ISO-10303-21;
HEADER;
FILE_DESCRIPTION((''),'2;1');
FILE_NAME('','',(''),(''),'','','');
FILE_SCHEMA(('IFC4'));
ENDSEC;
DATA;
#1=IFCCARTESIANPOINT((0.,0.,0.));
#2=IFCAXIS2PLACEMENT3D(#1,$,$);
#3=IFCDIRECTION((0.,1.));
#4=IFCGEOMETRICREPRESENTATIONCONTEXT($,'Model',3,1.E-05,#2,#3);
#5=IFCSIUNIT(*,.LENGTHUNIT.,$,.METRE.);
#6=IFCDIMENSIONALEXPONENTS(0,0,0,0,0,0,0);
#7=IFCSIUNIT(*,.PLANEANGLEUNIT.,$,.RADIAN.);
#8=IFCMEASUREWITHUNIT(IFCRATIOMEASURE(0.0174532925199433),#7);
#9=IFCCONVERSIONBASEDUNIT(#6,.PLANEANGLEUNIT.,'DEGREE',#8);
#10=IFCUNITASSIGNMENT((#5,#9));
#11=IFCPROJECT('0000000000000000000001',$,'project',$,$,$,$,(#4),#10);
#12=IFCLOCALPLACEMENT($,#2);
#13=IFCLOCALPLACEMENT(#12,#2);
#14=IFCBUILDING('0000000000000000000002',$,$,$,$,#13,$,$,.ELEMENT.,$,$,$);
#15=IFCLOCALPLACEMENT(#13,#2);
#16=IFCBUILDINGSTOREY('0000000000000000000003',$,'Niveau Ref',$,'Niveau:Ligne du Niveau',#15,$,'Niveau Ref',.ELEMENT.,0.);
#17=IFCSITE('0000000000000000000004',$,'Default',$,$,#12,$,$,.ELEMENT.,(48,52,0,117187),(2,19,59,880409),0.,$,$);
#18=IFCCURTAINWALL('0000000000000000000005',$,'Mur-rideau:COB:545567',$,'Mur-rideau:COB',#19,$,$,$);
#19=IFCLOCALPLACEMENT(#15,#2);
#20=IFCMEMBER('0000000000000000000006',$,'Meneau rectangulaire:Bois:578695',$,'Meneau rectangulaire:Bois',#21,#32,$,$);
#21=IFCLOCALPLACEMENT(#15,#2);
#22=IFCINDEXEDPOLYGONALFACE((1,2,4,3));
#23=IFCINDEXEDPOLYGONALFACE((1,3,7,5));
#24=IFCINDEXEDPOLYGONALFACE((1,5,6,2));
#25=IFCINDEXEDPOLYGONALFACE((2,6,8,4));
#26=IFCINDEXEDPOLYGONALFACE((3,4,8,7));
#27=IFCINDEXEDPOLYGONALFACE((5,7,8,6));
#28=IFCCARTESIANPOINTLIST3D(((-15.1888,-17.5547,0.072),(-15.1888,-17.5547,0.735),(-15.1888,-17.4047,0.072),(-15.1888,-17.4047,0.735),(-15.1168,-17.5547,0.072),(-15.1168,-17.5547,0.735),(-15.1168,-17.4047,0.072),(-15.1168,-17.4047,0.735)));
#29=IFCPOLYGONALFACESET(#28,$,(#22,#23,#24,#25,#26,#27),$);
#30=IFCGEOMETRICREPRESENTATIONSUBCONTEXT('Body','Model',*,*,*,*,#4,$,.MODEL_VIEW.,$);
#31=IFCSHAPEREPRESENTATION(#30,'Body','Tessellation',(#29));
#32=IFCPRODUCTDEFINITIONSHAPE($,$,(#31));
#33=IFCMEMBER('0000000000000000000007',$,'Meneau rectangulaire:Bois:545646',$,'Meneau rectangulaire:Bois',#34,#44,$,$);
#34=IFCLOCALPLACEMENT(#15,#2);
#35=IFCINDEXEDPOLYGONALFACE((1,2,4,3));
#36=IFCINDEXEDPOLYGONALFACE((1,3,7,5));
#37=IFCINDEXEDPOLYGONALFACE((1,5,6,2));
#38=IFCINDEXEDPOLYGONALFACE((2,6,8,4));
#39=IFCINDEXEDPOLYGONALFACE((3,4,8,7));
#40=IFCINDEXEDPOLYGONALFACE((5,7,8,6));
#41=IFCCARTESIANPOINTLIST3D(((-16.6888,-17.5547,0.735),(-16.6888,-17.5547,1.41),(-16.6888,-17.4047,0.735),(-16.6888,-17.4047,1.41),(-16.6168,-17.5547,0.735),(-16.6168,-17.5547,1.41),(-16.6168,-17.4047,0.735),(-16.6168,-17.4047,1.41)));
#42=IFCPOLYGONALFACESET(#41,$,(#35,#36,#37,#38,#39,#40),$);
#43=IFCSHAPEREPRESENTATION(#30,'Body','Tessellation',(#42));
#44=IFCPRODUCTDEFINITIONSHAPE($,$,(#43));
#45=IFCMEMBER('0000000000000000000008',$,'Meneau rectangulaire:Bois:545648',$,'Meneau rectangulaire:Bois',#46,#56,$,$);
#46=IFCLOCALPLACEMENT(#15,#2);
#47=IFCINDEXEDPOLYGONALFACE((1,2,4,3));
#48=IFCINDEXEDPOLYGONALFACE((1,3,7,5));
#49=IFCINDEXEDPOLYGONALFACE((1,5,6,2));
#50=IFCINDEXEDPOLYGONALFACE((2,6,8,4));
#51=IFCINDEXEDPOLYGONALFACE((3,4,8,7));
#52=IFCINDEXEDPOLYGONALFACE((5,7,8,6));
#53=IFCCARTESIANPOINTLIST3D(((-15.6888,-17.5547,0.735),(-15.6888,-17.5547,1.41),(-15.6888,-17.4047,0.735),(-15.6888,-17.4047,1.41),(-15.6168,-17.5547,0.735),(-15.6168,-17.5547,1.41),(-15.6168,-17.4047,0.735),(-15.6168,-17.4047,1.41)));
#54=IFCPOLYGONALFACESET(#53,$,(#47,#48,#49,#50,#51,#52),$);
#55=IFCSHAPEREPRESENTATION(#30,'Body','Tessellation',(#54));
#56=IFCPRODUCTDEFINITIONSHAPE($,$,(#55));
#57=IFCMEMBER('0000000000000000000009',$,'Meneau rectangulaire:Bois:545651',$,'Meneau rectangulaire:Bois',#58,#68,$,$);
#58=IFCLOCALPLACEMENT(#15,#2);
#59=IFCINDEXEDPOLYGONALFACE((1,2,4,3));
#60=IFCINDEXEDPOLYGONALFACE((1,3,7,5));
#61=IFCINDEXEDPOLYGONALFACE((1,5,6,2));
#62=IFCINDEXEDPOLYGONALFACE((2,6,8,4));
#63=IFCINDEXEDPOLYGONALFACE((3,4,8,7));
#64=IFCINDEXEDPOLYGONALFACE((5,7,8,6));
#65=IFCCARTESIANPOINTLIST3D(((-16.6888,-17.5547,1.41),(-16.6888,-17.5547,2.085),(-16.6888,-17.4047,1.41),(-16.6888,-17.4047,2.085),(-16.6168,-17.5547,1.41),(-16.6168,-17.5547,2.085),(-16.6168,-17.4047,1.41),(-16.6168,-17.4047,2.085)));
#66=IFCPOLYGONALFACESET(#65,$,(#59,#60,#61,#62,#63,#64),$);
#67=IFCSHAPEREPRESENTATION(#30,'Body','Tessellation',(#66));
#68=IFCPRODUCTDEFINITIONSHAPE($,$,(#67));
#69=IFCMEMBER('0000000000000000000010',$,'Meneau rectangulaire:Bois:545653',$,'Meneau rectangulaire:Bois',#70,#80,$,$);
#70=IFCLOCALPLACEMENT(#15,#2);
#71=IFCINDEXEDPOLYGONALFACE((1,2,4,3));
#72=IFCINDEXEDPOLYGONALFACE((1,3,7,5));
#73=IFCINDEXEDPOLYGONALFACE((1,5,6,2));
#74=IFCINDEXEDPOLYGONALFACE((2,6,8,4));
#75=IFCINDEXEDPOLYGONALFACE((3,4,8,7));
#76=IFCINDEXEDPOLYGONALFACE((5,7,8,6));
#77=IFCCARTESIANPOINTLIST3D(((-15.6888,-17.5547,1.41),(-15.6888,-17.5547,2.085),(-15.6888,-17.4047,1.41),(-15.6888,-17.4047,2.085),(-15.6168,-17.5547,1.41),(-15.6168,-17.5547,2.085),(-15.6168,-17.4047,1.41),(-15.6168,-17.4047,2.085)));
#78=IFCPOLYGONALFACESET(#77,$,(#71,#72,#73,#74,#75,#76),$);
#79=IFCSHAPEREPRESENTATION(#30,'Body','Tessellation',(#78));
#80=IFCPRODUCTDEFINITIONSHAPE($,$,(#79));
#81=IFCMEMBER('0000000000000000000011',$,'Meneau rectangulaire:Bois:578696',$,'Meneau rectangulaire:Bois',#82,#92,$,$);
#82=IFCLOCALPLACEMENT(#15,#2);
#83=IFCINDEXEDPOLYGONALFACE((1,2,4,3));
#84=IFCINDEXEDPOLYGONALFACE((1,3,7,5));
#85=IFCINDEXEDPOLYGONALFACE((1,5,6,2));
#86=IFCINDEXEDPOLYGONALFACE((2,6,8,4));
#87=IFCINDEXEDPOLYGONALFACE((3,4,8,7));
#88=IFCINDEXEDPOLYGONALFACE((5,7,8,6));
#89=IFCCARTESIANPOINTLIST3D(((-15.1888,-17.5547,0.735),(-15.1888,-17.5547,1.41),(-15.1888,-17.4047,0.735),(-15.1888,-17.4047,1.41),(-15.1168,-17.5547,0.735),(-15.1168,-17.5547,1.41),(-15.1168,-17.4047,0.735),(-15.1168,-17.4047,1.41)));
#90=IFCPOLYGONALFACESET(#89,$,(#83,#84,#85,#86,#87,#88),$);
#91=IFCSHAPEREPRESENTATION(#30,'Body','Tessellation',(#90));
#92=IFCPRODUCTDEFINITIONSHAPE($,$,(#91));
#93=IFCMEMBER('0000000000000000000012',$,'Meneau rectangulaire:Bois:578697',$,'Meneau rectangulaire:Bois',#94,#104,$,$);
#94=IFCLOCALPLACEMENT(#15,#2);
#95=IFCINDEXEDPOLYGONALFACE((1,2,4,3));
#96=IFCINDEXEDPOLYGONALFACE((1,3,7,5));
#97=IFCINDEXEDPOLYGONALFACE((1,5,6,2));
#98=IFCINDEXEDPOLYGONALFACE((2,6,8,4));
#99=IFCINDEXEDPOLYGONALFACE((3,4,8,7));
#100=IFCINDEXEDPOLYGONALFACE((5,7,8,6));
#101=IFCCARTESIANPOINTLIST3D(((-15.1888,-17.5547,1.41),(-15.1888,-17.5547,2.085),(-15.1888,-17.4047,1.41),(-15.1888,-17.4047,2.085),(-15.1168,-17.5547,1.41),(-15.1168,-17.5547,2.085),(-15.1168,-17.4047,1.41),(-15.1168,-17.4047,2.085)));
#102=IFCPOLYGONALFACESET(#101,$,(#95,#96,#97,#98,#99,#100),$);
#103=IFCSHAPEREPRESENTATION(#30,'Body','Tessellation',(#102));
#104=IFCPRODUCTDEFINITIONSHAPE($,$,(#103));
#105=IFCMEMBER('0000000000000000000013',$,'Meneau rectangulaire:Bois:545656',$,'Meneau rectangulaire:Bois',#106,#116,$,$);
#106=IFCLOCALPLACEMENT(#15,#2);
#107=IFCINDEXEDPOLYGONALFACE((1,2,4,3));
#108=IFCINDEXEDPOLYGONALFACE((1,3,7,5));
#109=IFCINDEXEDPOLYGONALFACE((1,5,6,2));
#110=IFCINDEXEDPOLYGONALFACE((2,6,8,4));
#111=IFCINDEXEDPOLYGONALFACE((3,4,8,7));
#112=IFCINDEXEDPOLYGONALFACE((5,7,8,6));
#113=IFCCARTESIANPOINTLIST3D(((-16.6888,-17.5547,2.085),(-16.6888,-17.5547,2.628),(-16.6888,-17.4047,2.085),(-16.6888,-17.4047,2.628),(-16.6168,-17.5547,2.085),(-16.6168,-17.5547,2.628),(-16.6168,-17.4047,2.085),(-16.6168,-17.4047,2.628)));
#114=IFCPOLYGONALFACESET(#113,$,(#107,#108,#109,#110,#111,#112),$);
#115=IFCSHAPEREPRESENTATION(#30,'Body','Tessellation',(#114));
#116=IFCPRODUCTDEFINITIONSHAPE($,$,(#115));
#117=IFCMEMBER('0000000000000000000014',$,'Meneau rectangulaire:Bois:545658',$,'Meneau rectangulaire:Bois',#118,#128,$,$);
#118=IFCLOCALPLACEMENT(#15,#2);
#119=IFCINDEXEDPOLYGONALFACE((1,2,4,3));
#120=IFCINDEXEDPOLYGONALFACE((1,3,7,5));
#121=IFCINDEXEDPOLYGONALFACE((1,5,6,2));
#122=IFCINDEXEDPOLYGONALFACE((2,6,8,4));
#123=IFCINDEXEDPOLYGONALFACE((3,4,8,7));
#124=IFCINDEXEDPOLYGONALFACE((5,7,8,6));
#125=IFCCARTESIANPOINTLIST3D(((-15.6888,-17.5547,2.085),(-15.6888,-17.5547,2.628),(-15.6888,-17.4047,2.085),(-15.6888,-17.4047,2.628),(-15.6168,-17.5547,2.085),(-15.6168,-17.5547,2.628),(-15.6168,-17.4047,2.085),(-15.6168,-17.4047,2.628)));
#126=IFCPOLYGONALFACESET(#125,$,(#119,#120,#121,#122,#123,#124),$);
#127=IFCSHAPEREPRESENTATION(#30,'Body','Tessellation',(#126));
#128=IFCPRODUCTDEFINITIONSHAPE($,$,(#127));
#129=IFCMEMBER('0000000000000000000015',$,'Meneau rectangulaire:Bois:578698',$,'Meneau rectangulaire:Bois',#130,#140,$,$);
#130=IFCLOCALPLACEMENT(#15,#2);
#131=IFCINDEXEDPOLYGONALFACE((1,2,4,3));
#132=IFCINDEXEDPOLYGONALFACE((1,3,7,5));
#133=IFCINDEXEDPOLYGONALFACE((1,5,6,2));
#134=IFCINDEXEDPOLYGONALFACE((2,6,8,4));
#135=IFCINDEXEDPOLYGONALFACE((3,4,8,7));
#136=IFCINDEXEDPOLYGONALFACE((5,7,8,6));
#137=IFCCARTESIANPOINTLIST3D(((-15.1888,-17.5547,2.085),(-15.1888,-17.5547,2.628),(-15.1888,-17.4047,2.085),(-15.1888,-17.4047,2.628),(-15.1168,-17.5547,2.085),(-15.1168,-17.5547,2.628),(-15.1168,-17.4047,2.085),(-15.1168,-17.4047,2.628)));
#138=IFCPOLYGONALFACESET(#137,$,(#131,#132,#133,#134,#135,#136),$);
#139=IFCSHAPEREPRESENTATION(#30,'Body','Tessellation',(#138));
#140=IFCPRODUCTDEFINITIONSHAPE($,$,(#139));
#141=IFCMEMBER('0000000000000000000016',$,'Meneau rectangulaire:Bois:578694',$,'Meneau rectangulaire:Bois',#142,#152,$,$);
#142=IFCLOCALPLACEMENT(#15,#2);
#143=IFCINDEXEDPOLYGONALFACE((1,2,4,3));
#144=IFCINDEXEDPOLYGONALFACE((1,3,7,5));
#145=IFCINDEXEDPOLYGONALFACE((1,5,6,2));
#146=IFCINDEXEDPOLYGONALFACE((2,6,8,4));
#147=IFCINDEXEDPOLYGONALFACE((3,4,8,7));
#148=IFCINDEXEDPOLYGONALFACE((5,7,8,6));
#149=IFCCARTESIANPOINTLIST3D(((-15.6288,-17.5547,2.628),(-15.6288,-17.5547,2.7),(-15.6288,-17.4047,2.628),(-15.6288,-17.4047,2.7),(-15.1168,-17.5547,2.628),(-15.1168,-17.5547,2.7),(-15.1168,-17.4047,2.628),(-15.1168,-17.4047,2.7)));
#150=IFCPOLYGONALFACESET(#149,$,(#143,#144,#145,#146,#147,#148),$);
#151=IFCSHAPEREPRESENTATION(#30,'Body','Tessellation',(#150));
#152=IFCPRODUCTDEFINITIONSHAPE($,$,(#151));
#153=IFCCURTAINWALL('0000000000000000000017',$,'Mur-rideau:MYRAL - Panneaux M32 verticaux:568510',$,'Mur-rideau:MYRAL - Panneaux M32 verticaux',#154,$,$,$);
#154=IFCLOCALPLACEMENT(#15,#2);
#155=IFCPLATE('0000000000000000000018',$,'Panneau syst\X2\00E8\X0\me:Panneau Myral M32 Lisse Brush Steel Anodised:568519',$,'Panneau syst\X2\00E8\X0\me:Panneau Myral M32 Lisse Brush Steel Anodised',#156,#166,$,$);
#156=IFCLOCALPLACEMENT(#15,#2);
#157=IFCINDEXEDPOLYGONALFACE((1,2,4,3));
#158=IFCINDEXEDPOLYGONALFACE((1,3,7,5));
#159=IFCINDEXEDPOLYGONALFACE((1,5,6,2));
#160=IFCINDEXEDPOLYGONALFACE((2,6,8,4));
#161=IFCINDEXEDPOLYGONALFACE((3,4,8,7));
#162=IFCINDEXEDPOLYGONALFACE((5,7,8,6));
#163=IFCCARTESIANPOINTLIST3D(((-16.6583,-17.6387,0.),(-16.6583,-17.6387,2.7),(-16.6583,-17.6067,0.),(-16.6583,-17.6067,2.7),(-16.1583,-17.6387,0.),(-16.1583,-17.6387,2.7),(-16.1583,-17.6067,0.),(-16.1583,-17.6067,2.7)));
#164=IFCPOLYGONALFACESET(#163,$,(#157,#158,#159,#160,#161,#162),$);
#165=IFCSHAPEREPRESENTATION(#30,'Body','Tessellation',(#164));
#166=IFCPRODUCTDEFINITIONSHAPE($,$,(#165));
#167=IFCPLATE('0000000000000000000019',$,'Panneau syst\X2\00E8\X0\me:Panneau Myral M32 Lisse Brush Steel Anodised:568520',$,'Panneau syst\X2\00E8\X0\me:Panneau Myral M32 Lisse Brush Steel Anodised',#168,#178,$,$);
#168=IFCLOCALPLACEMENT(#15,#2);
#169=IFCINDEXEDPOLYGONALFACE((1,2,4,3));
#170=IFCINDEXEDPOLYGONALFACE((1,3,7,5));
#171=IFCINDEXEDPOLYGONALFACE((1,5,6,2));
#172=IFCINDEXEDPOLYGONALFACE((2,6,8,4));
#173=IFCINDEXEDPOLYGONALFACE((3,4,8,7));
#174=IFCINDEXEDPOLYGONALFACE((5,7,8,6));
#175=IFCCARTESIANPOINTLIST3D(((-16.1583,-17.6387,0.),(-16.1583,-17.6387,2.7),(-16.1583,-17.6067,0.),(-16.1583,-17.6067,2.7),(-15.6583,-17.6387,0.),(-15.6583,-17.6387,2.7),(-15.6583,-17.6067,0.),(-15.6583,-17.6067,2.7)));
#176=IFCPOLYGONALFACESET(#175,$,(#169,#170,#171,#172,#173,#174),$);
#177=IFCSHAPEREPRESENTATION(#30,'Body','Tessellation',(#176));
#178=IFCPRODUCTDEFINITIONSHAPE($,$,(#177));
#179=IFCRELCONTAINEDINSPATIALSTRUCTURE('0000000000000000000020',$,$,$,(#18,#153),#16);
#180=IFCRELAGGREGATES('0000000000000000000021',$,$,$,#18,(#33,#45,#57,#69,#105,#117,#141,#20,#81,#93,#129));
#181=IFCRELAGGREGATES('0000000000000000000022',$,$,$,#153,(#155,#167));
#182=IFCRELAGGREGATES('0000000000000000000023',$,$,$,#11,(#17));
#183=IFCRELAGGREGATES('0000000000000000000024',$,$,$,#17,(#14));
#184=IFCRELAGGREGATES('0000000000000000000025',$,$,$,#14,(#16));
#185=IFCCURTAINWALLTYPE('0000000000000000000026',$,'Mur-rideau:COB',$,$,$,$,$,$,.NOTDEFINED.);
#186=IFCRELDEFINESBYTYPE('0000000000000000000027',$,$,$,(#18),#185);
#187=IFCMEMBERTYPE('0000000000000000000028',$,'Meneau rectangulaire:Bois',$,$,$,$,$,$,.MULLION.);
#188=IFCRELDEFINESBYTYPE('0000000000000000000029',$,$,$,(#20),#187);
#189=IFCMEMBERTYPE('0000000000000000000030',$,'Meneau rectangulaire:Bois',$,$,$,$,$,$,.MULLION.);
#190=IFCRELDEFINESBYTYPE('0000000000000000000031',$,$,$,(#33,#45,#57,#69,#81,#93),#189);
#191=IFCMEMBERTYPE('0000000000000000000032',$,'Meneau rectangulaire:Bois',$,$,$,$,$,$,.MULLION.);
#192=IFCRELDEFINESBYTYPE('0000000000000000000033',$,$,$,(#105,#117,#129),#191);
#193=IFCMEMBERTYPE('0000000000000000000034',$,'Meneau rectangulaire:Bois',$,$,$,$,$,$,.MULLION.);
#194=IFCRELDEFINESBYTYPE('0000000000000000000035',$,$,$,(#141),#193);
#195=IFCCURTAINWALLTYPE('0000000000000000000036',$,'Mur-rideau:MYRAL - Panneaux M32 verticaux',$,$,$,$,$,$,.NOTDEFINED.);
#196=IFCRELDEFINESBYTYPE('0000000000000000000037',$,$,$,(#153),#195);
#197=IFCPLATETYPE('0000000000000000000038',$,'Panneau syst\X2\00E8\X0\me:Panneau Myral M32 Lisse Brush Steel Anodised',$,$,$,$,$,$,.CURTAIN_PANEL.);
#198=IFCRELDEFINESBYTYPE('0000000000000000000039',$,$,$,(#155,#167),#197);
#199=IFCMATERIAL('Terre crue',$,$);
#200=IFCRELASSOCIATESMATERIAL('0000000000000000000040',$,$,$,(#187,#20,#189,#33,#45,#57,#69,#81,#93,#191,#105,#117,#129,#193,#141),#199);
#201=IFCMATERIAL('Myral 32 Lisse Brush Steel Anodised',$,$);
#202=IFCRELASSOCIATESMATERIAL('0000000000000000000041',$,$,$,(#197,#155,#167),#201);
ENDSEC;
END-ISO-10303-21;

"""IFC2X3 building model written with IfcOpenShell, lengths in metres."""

from ifc_helpers import new_model, entity, si_unit, converted_unit, direction, frame, origin, origin_2d_with_axis, place, context, subcontext, project, spatial, rectangle, extrude, source, transform, mapped, material, type_object, type_shapes, element, aggregate, save


model = new_model("IFC2X3")

# Units and contexts
model_context = context("Model", 3, precision=1e-05, world=origin(), true_north=direction((0.0, 1.0)))
body_context = subcontext(model_context, "Body", "Model", "MODEL_VIEW")
ifc_project = project(units=[si_unit("LENGTHUNIT", "METRE"), converted_unit("PLANEANGLEUNIT", "DEGREE", entity("IfcRatioMeasure", 0.0174532925199433), si_unit("PLANEANGLEUNIT", "RADIAN"), dimensions=[0, 0, 0, 0, 0, 0, 0])], contexts=[model_context])

# Site, building, storey
site_placement = place(None, origin())
site = spatial("IfcSite", under=ifc_project, at=site_placement, Name="Default", CompositionType="ELEMENT", RefLatitude=(48, 52, 0, 117187), RefLongitude=(2, 19, 59, 880409), RefElevation=0.0)
building_placement = place(site_placement, origin())
building = spatial("IfcBuilding", under=site, at=building_placement, CompositionType="ELEMENT")
storey_placement = place(building_placement, origin())
storey = spatial("IfcBuildingStorey", under=building, at=storey_placement, Name="Niveau Ref", ObjectType="Niveau:Ligne du Niveau", LongName="Niveau Ref", CompositionType="ELEMENT", Elevation=0.0)

# Curtain wall, members
curtain_wall_type_1 = type_object("IfcCurtainWallType", Name="Mur-rideau:COB", PredefinedType="NOTDEFINED")
curtain_wall_1_placement = place(storey_placement, origin())
curtain_wall_1 = element("IfcCurtainWall", 1, at=curtain_wall_1_placement, inside=storey, type_object=curtain_wall_type_1, Name="Mur-rideau:COB:545567", ObjectType="Mur-rideau:COB")
ifc_material_1 = material(Name="Terre crue")
member_type_1 = type_object("IfcMemberType", Name="Meneau rectangulaire:Bois", PredefinedType="MULLION", material=ifc_material_1)
shared_shape_1 = source(origin(), body_context, "Body", "SweptSolid", [
    extrude(rectangle(XDim=0.15, YDim=0.072, at=origin_2d_with_axis()), frame((-0.024, 0.0, -0.663), z_axis=(0.0, 0.0, 1.0), x_axis=(0.0, -1.0, 0.0)), (0.0, 0.0, 1.0), 0.663),
])
type_shapes(member_type_1, [shared_shape_1])
member_1_placement = place(storey_placement, frame((-15.1288, -17.4797, 0.072), z_axis=(0.0, 0.0, -1.0), x_axis=(1.0, 0.0, 0.0)))
member_1 = element("IfcMember", 2, at=member_1_placement, type_object=member_type_1, material=ifc_material_1, Name="Meneau rectangulaire:Bois:578695", ObjectType="Meneau rectangulaire:Bois", context=body_context, shape_type="MappedRepresentation", body=[
    mapped(shared_shape_1, transform((0.0, 0.0, 0.0), scale=1.0)),
])
member_type_2 = type_object("IfcMemberType", Name="Meneau rectangulaire:Bois", PredefinedType="MULLION", material=ifc_material_1)
shared_shape_2 = source(origin(), body_context, "Body", "SweptSolid", [
    extrude(rectangle(XDim=0.15, YDim=0.072, at=origin_2d_with_axis()), frame((-0.024, 0.0, -0.675), z_axis=(0.0, 0.0, 1.0), x_axis=(0.0, -1.0, 0.0)), (0.0, 0.0, 1.0), 0.675),
])
type_shapes(member_type_2, [shared_shape_2])
member_2_placement = place(storey_placement, frame((-16.6288, -17.4797, 0.735), z_axis=(0.0, 0.0, -1.0), x_axis=(1.0, 0.0, 0.0)))
member_2 = element("IfcMember", 3, at=member_2_placement, type_object=member_type_2, material=ifc_material_1, Name="Meneau rectangulaire:Bois:545646", ObjectType="Meneau rectangulaire:Bois", context=body_context, shape_type="MappedRepresentation", body=[
    mapped(shared_shape_2, transform((0.0, 0.0, 0.0), scale=1.0)),
])
member_3_placement = place(storey_placement, frame((-15.6288, -17.4797, 0.735), z_axis=(0.0, 0.0, -1.0), x_axis=(1.0, 0.0, 0.0)))
member_3 = element("IfcMember", 4, at=member_3_placement, type_object=member_type_2, material=ifc_material_1, Name="Meneau rectangulaire:Bois:545648", ObjectType="Meneau rectangulaire:Bois", context=body_context, shape_type="MappedRepresentation", body=[
    mapped(shared_shape_2, transform((0.0, 0.0, 0.0), scale=1.0)),
])
member_4_placement = place(storey_placement, frame((-16.6288, -17.4797, 1.41), z_axis=(0.0, 0.0, -1.0), x_axis=(1.0, 0.0, 0.0)))
member_4 = element("IfcMember", 5, at=member_4_placement, type_object=member_type_2, material=ifc_material_1, Name="Meneau rectangulaire:Bois:545651", ObjectType="Meneau rectangulaire:Bois", context=body_context, shape_type="MappedRepresentation", body=[
    mapped(shared_shape_2, transform((0.0, 0.0, 0.0), scale=1.0)),
])
member_5_placement = place(storey_placement, frame((-15.6288, -17.4797, 1.41), z_axis=(0.0, 0.0, -1.0), x_axis=(1.0, 0.0, 0.0)))
member_5 = element("IfcMember", 6, at=member_5_placement, type_object=member_type_2, material=ifc_material_1, Name="Meneau rectangulaire:Bois:545653", ObjectType="Meneau rectangulaire:Bois", context=body_context, shape_type="MappedRepresentation", body=[
    mapped(shared_shape_2, transform((0.0, 0.0, 0.0), scale=1.0)),
])
member_6_placement = place(storey_placement, frame((-15.1288, -17.4797, 0.735), z_axis=(0.0, 0.0, -1.0), x_axis=(1.0, 0.0, 0.0)))
member_6 = element("IfcMember", 7, at=member_6_placement, type_object=member_type_2, material=ifc_material_1, Name="Meneau rectangulaire:Bois:578696", ObjectType="Meneau rectangulaire:Bois", context=body_context, shape_type="MappedRepresentation", body=[
    mapped(shared_shape_2, transform((0.0, 0.0, 0.0), scale=1.0)),
])
member_7_placement = place(storey_placement, frame((-15.1288, -17.4797, 1.41), z_axis=(0.0, 0.0, -1.0), x_axis=(1.0, 0.0, 0.0)))
member_7 = element("IfcMember", 8, at=member_7_placement, type_object=member_type_2, material=ifc_material_1, Name="Meneau rectangulaire:Bois:578697", ObjectType="Meneau rectangulaire:Bois", context=body_context, shape_type="MappedRepresentation", body=[
    mapped(shared_shape_2, transform((0.0, 0.0, 0.0), scale=1.0)),
])
member_type_3 = type_object("IfcMemberType", Name="Meneau rectangulaire:Bois", PredefinedType="MULLION", material=ifc_material_1)
shared_shape_3 = source(origin(), body_context, "Body", "SweptSolid", [
    extrude(rectangle(XDim=0.15, YDim=0.072, at=origin_2d_with_axis()), frame((-0.024, 0.0, -0.543), z_axis=(0.0, 0.0, 1.0), x_axis=(0.0, -1.0, 0.0)), (0.0, 0.0, 1.0), 0.543),
])
type_shapes(member_type_3, [shared_shape_3])
member_8_placement = place(storey_placement, frame((-16.6288, -17.4797, 2.085), z_axis=(0.0, 0.0, -1.0), x_axis=(1.0, 0.0, 0.0)))
member_8 = element("IfcMember", 9, at=member_8_placement, type_object=member_type_3, material=ifc_material_1, Name="Meneau rectangulaire:Bois:545656", ObjectType="Meneau rectangulaire:Bois", context=body_context, shape_type="MappedRepresentation", body=[
    mapped(shared_shape_3, transform((0.0, 0.0, 0.0), scale=1.0)),
])
member_9_placement = place(storey_placement, frame((-15.6288, -17.4797, 2.085), z_axis=(0.0, 0.0, -1.0), x_axis=(1.0, 0.0, 0.0)))
member_9 = element("IfcMember", 10, at=member_9_placement, type_object=member_type_3, material=ifc_material_1, Name="Meneau rectangulaire:Bois:545658", ObjectType="Meneau rectangulaire:Bois", context=body_context, shape_type="MappedRepresentation", body=[
    mapped(shared_shape_3, transform((0.0, 0.0, 0.0), scale=1.0)),
])
member_10_placement = place(storey_placement, frame((-15.1288, -17.4797, 2.085), z_axis=(0.0, 0.0, -1.0), x_axis=(1.0, 0.0, 0.0)))
member_10 = element("IfcMember", 11, at=member_10_placement, type_object=member_type_3, material=ifc_material_1, Name="Meneau rectangulaire:Bois:578698", ObjectType="Meneau rectangulaire:Bois", context=body_context, shape_type="MappedRepresentation", body=[
    mapped(shared_shape_3, transform((0.0, 0.0, 0.0), scale=1.0)),
])
member_type_4 = type_object("IfcMemberType", Name="Meneau rectangulaire:Bois", PredefinedType="MULLION", material=ifc_material_1)
shared_shape_4 = source(origin(), body_context, "Body", "SweptSolid", [
    extrude(rectangle(XDim=0.15, YDim=0.072, at=origin_2d_with_axis()), frame((-0.036, 0.0, -0.512), z_axis=(0.0, 0.0, 1.0), x_axis=(0.0, -1.0, 0.0)), (0.0, 0.0, 1.0), 0.512),
])
type_shapes(member_type_4, [shared_shape_4])
member_11_placement = place(storey_placement, frame((-15.1168, -17.4797, 2.7), z_axis=(1.0, 0.0, 0.0), x_axis=(0.0, 0.0, 1.0)))
member_11 = element("IfcMember", 12, at=member_11_placement, type_object=member_type_4, material=ifc_material_1, Name="Meneau rectangulaire:Bois:578694", ObjectType="Meneau rectangulaire:Bois", context=body_context, shape_type="MappedRepresentation", body=[
    mapped(shared_shape_4, transform((0.0, 0.0, 0.0), scale=1.0)),
])
aggregate(curtain_wall_1, [member_2, member_3, member_4, member_5, member_8, member_9, member_11, member_1, member_6, member_7, member_10])

# Curtain wall, plates
curtain_wall_type_2 = type_object("IfcCurtainWallType", Name="Mur-rideau:MYRAL - Panneaux M32 verticaux", PredefinedType="NOTDEFINED")
curtain_wall_2_placement = place(storey_placement, origin())
curtain_wall_2 = element("IfcCurtainWall", 13, at=curtain_wall_2_placement, inside=storey, type_object=curtain_wall_type_2, Name="Mur-rideau:MYRAL - Panneaux M32 verticaux:568510", ObjectType="Mur-rideau:MYRAL - Panneaux M32 verticaux")
ifc_material_2 = material(Name="Myral 32 Lisse Brush Steel Anodised")
plate_type = type_object("IfcPlateType", Name="Panneau système:Panneau Myral M32 Lisse Brush Steel Anodised", PredefinedType="CURTAIN_PANEL", material=ifc_material_2)
shared_shape_5 = source(origin(), body_context, "Body", "SweptSolid", [
    extrude(rectangle(XDim=0.032, YDim=0.5, at=origin_2d_with_axis()), frame((0.0, -0.016, 0.0), z_axis=(0.0, 0.0, 1.0), x_axis=(0.0, 1.0, 0.0)), (0.0, 0.0, 1.0), 2.7),
])
type_shapes(plate_type, [shared_shape_5])
plate_1_placement = place(curtain_wall_2_placement, frame((-16.4083, -17.6067, 0.0)))
plate_1 = element("IfcPlate", 14, at=plate_1_placement, type_object=plate_type, material=ifc_material_2, Name="Panneau système:Panneau Myral M32 Lisse Brush Steel Anodised:568519", ObjectType="Panneau système:Panneau Myral M32 Lisse Brush Steel Anodised", context=body_context, shape_type="MappedRepresentation", body=[
    mapped(shared_shape_5, transform((0.0, 0.0, 0.0), scale=1.0)),
])
plate_2_placement = place(curtain_wall_2_placement, frame((-15.9083, -17.6067, 0.0)))
plate_2 = element("IfcPlate", 15, at=plate_2_placement, type_object=plate_type, material=ifc_material_2, Name="Panneau système:Panneau Myral M32 Lisse Brush Steel Anodised:568520", ObjectType="Panneau système:Panneau Myral M32 Lisse Brush Steel Anodised", context=body_context, shape_type="MappedRepresentation", body=[
    mapped(shared_shape_5, transform((0.0, 0.0, 0.0), scale=1.0)),
])
aggregate(curtain_wall_2, [plate_1, plate_2])

save(model, "model.ifc")
